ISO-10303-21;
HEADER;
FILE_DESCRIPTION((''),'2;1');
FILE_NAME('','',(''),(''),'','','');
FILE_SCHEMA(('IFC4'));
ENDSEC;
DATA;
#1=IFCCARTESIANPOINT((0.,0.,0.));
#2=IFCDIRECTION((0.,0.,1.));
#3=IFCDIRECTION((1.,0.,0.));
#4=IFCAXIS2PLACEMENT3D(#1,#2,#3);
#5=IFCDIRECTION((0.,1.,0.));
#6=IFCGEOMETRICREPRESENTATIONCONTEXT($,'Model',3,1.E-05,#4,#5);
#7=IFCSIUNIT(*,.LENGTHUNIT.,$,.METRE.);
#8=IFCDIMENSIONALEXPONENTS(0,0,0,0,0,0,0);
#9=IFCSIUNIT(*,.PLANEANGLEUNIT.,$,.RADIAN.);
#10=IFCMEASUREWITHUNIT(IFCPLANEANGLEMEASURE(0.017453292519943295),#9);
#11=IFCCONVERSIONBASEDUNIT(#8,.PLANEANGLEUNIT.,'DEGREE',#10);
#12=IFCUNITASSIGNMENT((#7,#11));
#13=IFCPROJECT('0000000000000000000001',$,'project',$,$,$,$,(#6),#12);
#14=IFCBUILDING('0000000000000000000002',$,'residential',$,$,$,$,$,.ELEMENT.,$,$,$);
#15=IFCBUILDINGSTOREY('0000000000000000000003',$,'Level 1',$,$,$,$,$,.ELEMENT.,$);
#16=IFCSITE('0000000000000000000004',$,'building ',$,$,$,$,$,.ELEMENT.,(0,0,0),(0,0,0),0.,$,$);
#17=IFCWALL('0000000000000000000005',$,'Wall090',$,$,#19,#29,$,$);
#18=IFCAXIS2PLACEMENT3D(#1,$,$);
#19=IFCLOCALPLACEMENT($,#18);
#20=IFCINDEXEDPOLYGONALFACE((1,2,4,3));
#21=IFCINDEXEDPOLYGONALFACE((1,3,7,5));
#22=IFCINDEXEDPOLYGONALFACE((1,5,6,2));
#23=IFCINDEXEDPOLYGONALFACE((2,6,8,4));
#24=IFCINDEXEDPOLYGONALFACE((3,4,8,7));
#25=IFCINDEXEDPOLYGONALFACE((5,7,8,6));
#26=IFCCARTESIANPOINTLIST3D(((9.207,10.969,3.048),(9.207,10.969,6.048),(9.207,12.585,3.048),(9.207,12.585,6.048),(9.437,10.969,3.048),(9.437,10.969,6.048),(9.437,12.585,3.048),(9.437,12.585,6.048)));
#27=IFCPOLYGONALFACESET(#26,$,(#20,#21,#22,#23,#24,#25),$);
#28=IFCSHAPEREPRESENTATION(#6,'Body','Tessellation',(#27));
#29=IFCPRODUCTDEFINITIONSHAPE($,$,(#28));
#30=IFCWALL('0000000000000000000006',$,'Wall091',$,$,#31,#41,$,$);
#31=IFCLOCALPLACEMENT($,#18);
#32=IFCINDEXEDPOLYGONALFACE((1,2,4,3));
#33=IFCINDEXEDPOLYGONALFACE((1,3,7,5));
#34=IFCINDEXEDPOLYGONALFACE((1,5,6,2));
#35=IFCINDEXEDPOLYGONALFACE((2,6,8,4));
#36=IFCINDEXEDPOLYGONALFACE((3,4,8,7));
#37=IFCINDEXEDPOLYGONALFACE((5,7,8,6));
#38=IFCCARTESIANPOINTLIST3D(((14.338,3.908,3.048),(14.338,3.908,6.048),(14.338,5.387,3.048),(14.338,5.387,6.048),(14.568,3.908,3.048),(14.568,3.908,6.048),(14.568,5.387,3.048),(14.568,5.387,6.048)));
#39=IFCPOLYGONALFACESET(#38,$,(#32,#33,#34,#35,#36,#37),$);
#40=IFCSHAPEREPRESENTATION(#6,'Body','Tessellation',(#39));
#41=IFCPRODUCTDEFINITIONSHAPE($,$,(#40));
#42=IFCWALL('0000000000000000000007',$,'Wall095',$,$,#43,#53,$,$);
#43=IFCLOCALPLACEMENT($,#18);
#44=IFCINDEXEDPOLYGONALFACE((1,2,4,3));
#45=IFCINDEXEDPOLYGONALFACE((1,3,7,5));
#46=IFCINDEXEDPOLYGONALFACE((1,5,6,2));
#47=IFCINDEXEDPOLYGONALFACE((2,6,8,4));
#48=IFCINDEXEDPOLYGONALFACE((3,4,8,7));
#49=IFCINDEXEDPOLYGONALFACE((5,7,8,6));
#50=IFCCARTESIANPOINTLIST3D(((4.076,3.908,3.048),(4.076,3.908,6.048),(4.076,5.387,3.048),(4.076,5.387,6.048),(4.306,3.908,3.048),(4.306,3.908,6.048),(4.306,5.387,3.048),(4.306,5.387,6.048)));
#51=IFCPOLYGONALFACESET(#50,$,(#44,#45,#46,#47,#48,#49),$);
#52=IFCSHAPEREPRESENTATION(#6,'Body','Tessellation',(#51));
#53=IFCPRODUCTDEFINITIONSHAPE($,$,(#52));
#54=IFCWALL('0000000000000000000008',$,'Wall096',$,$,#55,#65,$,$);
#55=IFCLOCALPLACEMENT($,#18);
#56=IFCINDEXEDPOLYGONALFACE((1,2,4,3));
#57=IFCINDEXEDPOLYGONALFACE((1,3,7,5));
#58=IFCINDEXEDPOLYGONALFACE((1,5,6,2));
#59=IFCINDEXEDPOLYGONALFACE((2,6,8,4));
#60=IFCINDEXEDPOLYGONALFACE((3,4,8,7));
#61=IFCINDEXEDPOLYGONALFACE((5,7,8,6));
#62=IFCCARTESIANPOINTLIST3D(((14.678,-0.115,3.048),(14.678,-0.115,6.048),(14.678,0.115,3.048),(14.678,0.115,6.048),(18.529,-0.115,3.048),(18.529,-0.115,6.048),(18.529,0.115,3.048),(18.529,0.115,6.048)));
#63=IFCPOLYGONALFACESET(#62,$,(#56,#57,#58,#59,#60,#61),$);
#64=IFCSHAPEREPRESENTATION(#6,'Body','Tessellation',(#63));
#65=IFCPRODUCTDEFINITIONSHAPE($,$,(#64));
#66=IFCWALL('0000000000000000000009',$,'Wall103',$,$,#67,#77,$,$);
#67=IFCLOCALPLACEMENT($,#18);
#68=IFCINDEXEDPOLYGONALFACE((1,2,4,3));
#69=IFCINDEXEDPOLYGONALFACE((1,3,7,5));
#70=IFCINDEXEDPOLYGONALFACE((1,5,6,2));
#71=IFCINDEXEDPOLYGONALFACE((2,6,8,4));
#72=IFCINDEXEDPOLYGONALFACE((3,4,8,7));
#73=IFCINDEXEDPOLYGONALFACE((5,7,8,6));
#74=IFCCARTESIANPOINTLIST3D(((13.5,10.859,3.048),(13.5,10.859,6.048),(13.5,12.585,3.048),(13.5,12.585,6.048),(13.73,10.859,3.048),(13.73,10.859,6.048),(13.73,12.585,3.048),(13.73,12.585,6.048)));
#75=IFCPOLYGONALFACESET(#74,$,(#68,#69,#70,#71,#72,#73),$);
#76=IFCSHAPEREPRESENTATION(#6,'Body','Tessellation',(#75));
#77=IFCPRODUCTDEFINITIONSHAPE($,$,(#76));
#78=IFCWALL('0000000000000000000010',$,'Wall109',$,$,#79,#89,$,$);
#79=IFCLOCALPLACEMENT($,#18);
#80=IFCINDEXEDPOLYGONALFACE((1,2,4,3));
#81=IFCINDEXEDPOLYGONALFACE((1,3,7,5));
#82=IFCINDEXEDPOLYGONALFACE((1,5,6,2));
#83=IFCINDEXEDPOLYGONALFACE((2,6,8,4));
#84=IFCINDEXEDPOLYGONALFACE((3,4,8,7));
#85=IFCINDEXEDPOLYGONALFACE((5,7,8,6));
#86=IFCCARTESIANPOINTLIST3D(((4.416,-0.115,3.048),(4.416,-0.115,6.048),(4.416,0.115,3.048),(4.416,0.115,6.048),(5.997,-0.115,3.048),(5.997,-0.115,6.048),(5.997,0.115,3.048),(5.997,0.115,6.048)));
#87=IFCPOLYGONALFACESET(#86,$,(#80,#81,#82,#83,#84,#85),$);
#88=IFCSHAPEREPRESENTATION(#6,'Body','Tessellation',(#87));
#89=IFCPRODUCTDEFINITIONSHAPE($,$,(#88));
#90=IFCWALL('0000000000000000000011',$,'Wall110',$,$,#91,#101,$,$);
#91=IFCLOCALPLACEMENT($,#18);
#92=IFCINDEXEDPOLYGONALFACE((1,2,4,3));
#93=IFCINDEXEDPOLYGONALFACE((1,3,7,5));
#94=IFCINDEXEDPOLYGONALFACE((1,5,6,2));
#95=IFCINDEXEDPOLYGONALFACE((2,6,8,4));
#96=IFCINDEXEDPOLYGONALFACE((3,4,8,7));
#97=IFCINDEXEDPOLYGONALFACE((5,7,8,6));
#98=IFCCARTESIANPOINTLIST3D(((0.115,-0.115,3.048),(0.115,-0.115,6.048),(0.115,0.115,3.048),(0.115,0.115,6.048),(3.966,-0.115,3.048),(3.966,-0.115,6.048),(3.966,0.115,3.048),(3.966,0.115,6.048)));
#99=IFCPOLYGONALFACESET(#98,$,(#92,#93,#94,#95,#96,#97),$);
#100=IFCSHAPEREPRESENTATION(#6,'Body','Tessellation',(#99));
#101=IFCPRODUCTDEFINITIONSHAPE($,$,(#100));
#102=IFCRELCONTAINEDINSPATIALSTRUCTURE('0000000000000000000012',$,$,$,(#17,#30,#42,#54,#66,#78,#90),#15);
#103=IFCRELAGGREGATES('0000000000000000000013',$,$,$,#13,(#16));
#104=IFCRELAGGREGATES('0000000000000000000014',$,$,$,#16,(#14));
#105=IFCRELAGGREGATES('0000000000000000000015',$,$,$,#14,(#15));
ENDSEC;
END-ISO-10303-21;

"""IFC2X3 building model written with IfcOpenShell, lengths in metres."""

from ifc_helpers import new_model, entity, si_unit, converted_unit, direction, frame, frame_2d, origin_with_axes, place, context, project, spatial, rectangle, extrude, element, save


model = new_model("IFC2X3")

# Units and contexts
model_context = context("Model", 3, precision=1e-05, world=origin_with_axes(), true_north=direction((0.0, 1.0, 0.0)))
ifc_project = project(units=[si_unit("LENGTHUNIT", "METRE"), converted_unit("PLANEANGLEUNIT", "DEGREE", entity("IfcPlaneAngleMeasure", 0.017453292519943295), si_unit("PLANEANGLEUNIT", "RADIAN"), dimensions=[0, 0, 0, 0, 0, 0, 0])], contexts=[model_context])

# Site, building, storey
site = spatial("IfcSite", under=ifc_project, Name="building ", CompositionType="ELEMENT", RefLatitude=(0, 0, 0), RefLongitude=(0, 0, 0), RefElevation=0.0)
building = spatial("IfcBuilding", under=site, Name="residential", CompositionType="ELEMENT")
storey = spatial("IfcBuildingStorey", under=building, Name="Level 1", CompositionType="ELEMENT")

# Shared definitions
placement = place(None, origin_with_axes())

# Walls
element("IfcWall", 1, at=placement, inside=storey, Name="Wall090", context=model_context, shape_type="SweptSolid", body=[
    extrude(rectangle(XDim=1.616, YDim=0.23, at=frame_2d((0.0, 0.0), x_axis=(0.0, -1.0, 0.0))), frame((9.322, 11.777, 3.048), z_axis=(0.0, 0.0, 1.0), x_axis=(1.0, 0.0, 0.0)), (0.0, 0.0, 1.0), 3.0),
])
element("IfcWall", 2, at=placement, inside=storey, Name="Wall091", context=model_context, shape_type="SweptSolid", body=[
    extrude(rectangle(XDim=1.479, YDim=0.23, at=frame_2d((0.0, 0.0), x_axis=(0.0, 1.0, 0.0))), frame((14.453, 4.6475, 3.048), z_axis=(0.0, 0.0, 1.0), x_axis=(1.0, 0.0, 0.0)), (0.0, 0.0, 1.0), 3.0),
])
element("IfcWall", 3, at=placement, inside=storey, Name="Wall095", context=model_context, shape_type="SweptSolid", body=[
    extrude(rectangle(XDim=1.479, YDim=0.23, at=frame_2d((0.0, 0.0), x_axis=(0.0, -1.0, 0.0))), frame((4.191, 4.6475, 3.048), z_axis=(0.0, 0.0, 1.0), x_axis=(1.0, 0.0, 0.0)), (0.0, 0.0, 1.0), 3.0),
])
element("IfcWall", 4, at=placement, inside=storey, Name="Wall096", context=model_context, shape_type="SweptSolid", body=[
    extrude(rectangle(XDim=3.851, YDim=0.23, at=frame_2d((0.0, 0.0), x_axis=(1.0, 0.0, 0.0))), frame((16.6035, 0.0, 3.048), z_axis=(0.0, 0.0, 1.0), x_axis=(1.0, 0.0, 0.0)), (0.0, 0.0, 1.0), 3.0),
])
element("IfcWall", 5, at=placement, inside=storey, Name="Wall103", context=model_context, shape_type="SweptSolid", body=[
    extrude(rectangle(XDim=1.726, YDim=0.23, at=frame_2d((0.0, 0.0), x_axis=(0.0, -1.0, 0.0))), frame((13.615, 11.722, 3.048), z_axis=(0.0, 0.0, 1.0), x_axis=(1.0, 0.0, 0.0)), (0.0, 0.0, 1.0), 3.0),
])
element("IfcWall", 6, at=placement, inside=storey, Name="Wall109", context=model_context, shape_type="SweptSolid", body=[
    extrude(rectangle(XDim=1.581, YDim=0.23, at=frame_2d((0.0, 0.0), x_axis=(1.0, 0.0, 0.0))), frame((5.2065, 0.0, 3.048), z_axis=(0.0, 0.0, 1.0), x_axis=(1.0, 0.0, 0.0)), (0.0, 0.0, 1.0), 3.0),
])
element("IfcWall", 7, at=placement, inside=storey, Name="Wall110", context=model_context, shape_type="SweptSolid", body=[
    extrude(rectangle(XDim=3.851, YDim=0.23, at=frame_2d((0.0, 0.0), x_axis=(1.0, 0.0, 0.0))), frame((2.0405, 0.0, 3.048), z_axis=(0.0, 0.0, 1.0), x_axis=(1.0, 0.0, 0.0)), (0.0, 0.0, 1.0), 3.0),
])

save(model, "model.ifc")
